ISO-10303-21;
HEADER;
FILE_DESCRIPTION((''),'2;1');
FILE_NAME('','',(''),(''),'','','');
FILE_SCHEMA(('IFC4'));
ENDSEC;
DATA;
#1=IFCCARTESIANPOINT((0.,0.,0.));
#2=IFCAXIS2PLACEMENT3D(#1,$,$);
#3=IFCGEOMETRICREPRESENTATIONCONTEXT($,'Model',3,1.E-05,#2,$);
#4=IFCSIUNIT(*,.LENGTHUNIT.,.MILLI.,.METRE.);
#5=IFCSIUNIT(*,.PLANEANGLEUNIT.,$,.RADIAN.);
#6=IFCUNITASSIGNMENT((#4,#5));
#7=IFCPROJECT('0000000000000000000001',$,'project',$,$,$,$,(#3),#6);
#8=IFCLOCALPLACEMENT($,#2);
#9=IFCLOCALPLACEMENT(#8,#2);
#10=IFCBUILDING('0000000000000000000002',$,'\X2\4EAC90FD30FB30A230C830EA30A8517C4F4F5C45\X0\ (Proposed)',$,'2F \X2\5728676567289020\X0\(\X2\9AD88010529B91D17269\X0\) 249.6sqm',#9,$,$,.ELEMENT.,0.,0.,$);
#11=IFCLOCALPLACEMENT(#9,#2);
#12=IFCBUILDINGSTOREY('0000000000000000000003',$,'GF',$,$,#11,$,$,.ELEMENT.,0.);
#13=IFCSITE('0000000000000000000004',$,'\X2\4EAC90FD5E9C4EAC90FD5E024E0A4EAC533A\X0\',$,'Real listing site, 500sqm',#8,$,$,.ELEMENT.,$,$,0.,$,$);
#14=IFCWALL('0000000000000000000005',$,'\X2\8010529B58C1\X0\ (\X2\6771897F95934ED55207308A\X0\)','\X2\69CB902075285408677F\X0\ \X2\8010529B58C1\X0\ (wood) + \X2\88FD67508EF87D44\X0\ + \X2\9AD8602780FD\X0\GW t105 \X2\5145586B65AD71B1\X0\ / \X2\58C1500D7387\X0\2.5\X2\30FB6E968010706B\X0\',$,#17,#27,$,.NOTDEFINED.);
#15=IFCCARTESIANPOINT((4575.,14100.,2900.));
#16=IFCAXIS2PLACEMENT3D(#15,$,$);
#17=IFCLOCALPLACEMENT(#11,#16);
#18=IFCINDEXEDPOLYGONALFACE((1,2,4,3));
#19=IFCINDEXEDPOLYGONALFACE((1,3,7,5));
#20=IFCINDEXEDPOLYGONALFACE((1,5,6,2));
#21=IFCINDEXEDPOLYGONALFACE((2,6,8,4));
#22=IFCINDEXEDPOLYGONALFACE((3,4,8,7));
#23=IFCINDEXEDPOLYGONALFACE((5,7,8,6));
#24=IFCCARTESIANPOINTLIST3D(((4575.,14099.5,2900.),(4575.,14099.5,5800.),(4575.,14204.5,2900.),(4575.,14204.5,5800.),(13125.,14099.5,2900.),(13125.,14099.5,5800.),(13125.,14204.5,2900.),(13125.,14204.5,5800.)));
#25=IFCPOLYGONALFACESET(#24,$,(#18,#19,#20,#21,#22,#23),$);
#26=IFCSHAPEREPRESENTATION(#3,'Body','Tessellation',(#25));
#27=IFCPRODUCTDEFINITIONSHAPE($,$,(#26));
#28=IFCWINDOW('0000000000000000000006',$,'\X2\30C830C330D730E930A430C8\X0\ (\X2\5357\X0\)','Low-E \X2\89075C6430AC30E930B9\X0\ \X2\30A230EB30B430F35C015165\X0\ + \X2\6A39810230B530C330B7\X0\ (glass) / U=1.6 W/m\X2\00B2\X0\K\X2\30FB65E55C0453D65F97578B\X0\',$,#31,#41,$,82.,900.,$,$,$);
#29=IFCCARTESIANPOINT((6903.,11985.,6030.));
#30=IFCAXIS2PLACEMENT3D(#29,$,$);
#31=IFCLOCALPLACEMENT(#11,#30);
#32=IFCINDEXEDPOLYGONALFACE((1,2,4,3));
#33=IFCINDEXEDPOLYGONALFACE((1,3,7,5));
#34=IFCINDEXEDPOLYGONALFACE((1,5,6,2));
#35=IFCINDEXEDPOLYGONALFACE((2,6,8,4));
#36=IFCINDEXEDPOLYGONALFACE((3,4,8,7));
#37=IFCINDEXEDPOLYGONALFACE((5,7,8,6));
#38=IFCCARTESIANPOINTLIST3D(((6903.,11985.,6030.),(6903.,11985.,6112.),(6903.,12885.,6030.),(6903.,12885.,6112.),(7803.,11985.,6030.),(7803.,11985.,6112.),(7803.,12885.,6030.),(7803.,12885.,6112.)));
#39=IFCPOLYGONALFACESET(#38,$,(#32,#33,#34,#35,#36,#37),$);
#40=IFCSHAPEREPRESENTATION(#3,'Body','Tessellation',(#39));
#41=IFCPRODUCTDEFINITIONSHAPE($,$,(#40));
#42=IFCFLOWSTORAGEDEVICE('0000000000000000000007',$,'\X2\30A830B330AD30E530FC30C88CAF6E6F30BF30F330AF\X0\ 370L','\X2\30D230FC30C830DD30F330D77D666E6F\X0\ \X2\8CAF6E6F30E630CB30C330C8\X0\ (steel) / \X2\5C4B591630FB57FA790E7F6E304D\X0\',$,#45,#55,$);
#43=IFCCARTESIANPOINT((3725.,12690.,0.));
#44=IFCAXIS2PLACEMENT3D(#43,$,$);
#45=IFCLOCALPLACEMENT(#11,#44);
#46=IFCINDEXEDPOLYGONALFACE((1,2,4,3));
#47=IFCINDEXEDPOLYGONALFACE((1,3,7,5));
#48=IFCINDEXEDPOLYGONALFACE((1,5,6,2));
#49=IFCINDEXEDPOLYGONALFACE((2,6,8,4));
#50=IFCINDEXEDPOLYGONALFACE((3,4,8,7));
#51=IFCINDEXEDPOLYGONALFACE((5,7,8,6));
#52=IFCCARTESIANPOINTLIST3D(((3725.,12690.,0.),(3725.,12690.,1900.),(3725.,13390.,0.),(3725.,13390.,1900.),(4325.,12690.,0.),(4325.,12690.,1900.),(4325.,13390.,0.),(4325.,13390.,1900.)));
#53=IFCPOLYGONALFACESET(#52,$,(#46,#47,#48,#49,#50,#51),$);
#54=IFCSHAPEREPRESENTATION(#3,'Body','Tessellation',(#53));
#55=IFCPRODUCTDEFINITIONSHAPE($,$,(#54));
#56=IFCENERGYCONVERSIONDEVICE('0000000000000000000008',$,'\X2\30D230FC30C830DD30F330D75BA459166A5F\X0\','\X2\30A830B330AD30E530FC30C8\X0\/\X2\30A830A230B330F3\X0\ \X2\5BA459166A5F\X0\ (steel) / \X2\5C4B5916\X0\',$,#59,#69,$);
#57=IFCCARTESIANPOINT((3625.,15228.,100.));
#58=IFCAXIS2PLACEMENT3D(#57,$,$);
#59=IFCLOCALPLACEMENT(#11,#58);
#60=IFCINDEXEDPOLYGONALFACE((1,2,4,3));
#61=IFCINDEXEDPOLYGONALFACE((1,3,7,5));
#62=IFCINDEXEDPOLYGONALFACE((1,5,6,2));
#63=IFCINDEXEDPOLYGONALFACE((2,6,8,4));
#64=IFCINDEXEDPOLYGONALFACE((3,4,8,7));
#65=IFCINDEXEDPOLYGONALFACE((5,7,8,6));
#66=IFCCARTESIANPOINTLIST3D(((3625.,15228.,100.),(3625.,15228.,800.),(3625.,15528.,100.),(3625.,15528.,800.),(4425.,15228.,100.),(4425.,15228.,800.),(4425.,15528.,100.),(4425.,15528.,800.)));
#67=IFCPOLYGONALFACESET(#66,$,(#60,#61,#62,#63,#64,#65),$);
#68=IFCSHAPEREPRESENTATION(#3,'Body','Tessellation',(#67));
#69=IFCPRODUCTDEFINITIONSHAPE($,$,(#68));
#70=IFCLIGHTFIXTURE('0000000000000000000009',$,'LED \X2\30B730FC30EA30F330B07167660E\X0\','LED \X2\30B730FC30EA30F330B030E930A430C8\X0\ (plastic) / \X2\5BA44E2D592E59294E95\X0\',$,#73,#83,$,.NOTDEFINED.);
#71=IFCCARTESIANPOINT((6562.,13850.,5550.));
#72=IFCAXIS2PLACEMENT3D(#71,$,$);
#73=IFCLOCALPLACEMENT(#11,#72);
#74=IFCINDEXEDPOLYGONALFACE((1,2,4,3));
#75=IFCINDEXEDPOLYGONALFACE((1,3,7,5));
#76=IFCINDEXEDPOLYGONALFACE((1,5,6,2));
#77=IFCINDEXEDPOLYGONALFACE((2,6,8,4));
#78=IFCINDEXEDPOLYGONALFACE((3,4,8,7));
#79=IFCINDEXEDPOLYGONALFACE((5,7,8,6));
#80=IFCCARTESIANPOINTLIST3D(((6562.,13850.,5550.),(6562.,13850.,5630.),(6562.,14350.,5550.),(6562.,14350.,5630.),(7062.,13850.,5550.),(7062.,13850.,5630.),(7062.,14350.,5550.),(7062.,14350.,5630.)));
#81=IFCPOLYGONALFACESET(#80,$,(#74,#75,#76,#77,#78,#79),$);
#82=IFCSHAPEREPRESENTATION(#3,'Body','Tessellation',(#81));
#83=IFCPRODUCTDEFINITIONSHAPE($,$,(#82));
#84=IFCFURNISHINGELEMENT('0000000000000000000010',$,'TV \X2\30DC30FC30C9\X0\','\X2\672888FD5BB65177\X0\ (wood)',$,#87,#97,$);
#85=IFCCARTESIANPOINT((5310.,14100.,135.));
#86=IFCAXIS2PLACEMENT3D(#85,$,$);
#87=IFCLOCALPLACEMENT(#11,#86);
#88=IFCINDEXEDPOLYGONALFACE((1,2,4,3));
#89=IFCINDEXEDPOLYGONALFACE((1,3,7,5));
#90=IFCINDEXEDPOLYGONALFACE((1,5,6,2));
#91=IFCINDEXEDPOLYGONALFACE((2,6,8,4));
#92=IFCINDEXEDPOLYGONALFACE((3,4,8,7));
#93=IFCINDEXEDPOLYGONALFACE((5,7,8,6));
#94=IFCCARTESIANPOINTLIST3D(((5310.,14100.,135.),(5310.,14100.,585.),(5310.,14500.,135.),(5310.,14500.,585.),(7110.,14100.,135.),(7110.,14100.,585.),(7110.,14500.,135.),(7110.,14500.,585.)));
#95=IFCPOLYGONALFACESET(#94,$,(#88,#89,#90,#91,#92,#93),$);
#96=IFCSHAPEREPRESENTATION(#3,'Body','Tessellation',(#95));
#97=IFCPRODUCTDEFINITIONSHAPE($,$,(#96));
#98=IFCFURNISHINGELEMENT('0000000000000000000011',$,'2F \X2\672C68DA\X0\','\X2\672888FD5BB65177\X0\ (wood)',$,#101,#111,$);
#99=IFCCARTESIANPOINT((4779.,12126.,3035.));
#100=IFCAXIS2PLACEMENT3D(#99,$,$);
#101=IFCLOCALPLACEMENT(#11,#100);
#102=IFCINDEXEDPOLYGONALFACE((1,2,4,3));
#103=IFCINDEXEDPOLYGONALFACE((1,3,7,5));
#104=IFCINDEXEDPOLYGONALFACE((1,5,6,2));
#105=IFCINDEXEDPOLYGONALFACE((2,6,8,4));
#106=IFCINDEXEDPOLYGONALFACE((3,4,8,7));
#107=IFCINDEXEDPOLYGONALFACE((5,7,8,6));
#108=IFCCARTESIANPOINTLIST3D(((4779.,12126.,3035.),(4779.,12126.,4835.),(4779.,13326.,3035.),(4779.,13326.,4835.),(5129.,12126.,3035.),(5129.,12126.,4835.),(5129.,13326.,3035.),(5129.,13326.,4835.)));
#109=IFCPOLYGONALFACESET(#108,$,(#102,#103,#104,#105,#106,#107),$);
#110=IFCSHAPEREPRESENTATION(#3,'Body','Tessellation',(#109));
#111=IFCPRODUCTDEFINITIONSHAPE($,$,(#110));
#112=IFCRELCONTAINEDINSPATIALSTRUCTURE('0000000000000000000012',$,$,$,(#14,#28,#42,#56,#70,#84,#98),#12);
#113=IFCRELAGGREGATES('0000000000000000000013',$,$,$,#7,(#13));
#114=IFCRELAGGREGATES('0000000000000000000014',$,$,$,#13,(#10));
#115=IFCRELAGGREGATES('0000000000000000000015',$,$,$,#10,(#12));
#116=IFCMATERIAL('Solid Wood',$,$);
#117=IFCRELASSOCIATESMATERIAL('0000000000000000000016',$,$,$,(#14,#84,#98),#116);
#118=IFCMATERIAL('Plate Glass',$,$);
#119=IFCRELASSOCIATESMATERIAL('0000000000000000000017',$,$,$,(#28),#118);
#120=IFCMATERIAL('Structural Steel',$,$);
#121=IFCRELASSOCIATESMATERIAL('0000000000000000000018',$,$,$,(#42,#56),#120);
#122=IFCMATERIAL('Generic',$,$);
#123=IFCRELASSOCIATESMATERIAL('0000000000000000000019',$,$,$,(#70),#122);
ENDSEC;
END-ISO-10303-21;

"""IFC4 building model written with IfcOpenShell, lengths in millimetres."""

from ifc_helpers import new_model, si_unit, frame, frame_2d, origin, place, context, project, spatial, rectangle, extrude, material, element, save


model = new_model("IFC4")

# Units and contexts
model_context = context("Model", 3, precision=1e-05, world=origin())
ifc_project = project(units=[si_unit("LENGTHUNIT", "METRE", prefix="MILLI"), si_unit("PLANEANGLEUNIT", "RADIAN")], contexts=[model_context])

# Site, building, storey
site_placement = place(None, origin())
site = spatial("IfcSite", under=ifc_project, at=site_placement, Name="京都府京都市上京区", ObjectType="Real listing site, 500sqm", CompositionType="ELEMENT", RefElevation=0.0)
building_placement = place(site_placement, origin())
building = spatial("IfcBuilding", under=site, at=building_placement, Name="京都・アトリエ兼住居 (Proposed)", ObjectType="2F 在来木造(高耐力金物) 249.6sqm", CompositionType="ELEMENT", ElevationOfRefHeight=0.0, ElevationOfTerrain=0.0)
storey_placement = place(building_placement, origin())
storey = spatial("IfcBuildingStorey", under=building, at=storey_placement, Name="GF", CompositionType="ELEMENT", Elevation=0.0)

# Shared definitions
ifc_material_1 = material(Name="Solid Wood")

# Wall
wall_1_placement = place(storey_placement, frame((4575.0, 14100.0, 2900.0)))
element("IfcWall", 1, at=wall_1_placement, inside=storey, material=ifc_material_1, Name="耐力壁 (東西間仕切り)", Description="構造用合板 耐力壁 (wood) + 製材軸組 + 高性能GW t105 充填断熱 / 壁倍率2.5・準耐火", PredefinedType="NOTDEFINED", context=model_context, shape_type="SweptSolid", body=[
    extrude(rectangle(XDim=8550.0, YDim=105.0, at=frame_2d((4275.0, 52.0))), frame((4575.0, 14100.0, 2900.0)), (0.0, 0.0, 1.0), 2900.0),
])

# Window
ifc_material_2 = material(Name="Plate Glass")
window_placement = place(storey_placement, frame((6903.0, 11985.0, 6030.0)))
element("IfcWindow", 2, at=window_placement, inside=storey, material=ifc_material_2, Name="トップライト (南)", Description="Low-E 複層ガラス アルゴン封入 + 樹脂サッシ (glass) / U=1.6 W/m²K・日射取得型", OverallHeight=82.0, OverallWidth=900.0, context=model_context, shape_type="SweptSolid", body=[
    extrude(rectangle(XDim=900.0, YDim=900.0, at=frame_2d((450.0, 450.0))), frame((6903.0, 11985.0, 6030.0)), (0.0, 0.0, 1.0), 82.0),
])

# Flow storage device
ifc_material_3 = material(Name="Structural Steel")
flow_storage_device_placement = place(storey_placement, frame((3725.0, 12690.0, 0.0)))
element("IfcFlowStorageDevice", 3, at=flow_storage_device_placement, inside=storey, material=ifc_material_3, Name="エコキュート貯湯タンク 370L", Description="ヒートポンプ給湯 貯湯ユニット (steel) / 屋外・基礎置き", context=model_context, shape_type="SweptSolid", body=[
    extrude(rectangle(XDim=600.0, YDim=700.0, at=frame_2d((300.0, 350.0))), frame((3725.0, 12690.0, 0.0)), (0.0, 0.0, 1.0), 1900.0),
])

# Energy conversion device
energy_conversion_device_placement = place(storey_placement, frame((3625.0, 15228.0, 100.0)))
element("IfcEnergyConversionDevice", 4, at=energy_conversion_device_placement, inside=storey, material=ifc_material_3, Name="ヒートポンプ室外機", Description="エコキュート/エアコン 室外機 (steel) / 屋外", context=model_context, shape_type="SweptSolid", body=[
    extrude(rectangle(XDim=800.0, YDim=300.0, at=frame_2d((400.0, 150.0))), frame((3625.0, 15228.0, 100.0)), (0.0, 0.0, 1.0), 700.0),
])

# Light fixture
ifc_material_4 = material(Name="Generic")
light_fixture_placement = place(storey_placement, frame((6562.0, 13850.0, 5550.0)))
element("IfcLightFixture", 5, at=light_fixture_placement, inside=storey, material=ifc_material_4, Name="LED シーリング照明", Description="LED シーリングライト (plastic) / 室中央天井", PredefinedType="NOTDEFINED", context=model_context, shape_type="SweptSolid", body=[
    extrude(rectangle(XDim=500.0, YDim=500.0, at=frame_2d((250.0, 250.0))), frame((6562.0, 13850.0, 5550.0)), (0.0, 0.0, 1.0), 80.0),
])

# Furnishing elements
furnishing_1_placement = place(storey_placement, frame((5310.0, 14100.0, 135.0)))
element("IfcFurnishingElement", 6, at=furnishing_1_placement, inside=storey, material=ifc_material_1, Name="TV ボード", Description="木製家具 (wood)", context=model_context, shape_type="SweptSolid", body=[
    extrude(rectangle(XDim=1800.0, YDim=400.0, at=frame_2d((900.0, 200.0))), frame((5310.0, 14100.0, 135.0)), (0.0, 0.0, 1.0), 450.0),
])
furnishing_2_placement = place(storey_placement, frame((4779.0, 12126.0, 3035.0)))
element("IfcFurnishingElement", 7, at=furnishing_2_placement, inside=storey, material=ifc_material_1, Name="2F 本棚", Description="木製家具 (wood)", context=model_context, shape_type="SweptSolid", body=[
    extrude(rectangle(XDim=350.0, YDim=1200.0, at=frame_2d((175.0, 600.0))), frame((4779.0, 12126.0, 3035.0)), (0.0, 0.0, 1.0), 1800.0),
])

save(model, "model.ifc")
